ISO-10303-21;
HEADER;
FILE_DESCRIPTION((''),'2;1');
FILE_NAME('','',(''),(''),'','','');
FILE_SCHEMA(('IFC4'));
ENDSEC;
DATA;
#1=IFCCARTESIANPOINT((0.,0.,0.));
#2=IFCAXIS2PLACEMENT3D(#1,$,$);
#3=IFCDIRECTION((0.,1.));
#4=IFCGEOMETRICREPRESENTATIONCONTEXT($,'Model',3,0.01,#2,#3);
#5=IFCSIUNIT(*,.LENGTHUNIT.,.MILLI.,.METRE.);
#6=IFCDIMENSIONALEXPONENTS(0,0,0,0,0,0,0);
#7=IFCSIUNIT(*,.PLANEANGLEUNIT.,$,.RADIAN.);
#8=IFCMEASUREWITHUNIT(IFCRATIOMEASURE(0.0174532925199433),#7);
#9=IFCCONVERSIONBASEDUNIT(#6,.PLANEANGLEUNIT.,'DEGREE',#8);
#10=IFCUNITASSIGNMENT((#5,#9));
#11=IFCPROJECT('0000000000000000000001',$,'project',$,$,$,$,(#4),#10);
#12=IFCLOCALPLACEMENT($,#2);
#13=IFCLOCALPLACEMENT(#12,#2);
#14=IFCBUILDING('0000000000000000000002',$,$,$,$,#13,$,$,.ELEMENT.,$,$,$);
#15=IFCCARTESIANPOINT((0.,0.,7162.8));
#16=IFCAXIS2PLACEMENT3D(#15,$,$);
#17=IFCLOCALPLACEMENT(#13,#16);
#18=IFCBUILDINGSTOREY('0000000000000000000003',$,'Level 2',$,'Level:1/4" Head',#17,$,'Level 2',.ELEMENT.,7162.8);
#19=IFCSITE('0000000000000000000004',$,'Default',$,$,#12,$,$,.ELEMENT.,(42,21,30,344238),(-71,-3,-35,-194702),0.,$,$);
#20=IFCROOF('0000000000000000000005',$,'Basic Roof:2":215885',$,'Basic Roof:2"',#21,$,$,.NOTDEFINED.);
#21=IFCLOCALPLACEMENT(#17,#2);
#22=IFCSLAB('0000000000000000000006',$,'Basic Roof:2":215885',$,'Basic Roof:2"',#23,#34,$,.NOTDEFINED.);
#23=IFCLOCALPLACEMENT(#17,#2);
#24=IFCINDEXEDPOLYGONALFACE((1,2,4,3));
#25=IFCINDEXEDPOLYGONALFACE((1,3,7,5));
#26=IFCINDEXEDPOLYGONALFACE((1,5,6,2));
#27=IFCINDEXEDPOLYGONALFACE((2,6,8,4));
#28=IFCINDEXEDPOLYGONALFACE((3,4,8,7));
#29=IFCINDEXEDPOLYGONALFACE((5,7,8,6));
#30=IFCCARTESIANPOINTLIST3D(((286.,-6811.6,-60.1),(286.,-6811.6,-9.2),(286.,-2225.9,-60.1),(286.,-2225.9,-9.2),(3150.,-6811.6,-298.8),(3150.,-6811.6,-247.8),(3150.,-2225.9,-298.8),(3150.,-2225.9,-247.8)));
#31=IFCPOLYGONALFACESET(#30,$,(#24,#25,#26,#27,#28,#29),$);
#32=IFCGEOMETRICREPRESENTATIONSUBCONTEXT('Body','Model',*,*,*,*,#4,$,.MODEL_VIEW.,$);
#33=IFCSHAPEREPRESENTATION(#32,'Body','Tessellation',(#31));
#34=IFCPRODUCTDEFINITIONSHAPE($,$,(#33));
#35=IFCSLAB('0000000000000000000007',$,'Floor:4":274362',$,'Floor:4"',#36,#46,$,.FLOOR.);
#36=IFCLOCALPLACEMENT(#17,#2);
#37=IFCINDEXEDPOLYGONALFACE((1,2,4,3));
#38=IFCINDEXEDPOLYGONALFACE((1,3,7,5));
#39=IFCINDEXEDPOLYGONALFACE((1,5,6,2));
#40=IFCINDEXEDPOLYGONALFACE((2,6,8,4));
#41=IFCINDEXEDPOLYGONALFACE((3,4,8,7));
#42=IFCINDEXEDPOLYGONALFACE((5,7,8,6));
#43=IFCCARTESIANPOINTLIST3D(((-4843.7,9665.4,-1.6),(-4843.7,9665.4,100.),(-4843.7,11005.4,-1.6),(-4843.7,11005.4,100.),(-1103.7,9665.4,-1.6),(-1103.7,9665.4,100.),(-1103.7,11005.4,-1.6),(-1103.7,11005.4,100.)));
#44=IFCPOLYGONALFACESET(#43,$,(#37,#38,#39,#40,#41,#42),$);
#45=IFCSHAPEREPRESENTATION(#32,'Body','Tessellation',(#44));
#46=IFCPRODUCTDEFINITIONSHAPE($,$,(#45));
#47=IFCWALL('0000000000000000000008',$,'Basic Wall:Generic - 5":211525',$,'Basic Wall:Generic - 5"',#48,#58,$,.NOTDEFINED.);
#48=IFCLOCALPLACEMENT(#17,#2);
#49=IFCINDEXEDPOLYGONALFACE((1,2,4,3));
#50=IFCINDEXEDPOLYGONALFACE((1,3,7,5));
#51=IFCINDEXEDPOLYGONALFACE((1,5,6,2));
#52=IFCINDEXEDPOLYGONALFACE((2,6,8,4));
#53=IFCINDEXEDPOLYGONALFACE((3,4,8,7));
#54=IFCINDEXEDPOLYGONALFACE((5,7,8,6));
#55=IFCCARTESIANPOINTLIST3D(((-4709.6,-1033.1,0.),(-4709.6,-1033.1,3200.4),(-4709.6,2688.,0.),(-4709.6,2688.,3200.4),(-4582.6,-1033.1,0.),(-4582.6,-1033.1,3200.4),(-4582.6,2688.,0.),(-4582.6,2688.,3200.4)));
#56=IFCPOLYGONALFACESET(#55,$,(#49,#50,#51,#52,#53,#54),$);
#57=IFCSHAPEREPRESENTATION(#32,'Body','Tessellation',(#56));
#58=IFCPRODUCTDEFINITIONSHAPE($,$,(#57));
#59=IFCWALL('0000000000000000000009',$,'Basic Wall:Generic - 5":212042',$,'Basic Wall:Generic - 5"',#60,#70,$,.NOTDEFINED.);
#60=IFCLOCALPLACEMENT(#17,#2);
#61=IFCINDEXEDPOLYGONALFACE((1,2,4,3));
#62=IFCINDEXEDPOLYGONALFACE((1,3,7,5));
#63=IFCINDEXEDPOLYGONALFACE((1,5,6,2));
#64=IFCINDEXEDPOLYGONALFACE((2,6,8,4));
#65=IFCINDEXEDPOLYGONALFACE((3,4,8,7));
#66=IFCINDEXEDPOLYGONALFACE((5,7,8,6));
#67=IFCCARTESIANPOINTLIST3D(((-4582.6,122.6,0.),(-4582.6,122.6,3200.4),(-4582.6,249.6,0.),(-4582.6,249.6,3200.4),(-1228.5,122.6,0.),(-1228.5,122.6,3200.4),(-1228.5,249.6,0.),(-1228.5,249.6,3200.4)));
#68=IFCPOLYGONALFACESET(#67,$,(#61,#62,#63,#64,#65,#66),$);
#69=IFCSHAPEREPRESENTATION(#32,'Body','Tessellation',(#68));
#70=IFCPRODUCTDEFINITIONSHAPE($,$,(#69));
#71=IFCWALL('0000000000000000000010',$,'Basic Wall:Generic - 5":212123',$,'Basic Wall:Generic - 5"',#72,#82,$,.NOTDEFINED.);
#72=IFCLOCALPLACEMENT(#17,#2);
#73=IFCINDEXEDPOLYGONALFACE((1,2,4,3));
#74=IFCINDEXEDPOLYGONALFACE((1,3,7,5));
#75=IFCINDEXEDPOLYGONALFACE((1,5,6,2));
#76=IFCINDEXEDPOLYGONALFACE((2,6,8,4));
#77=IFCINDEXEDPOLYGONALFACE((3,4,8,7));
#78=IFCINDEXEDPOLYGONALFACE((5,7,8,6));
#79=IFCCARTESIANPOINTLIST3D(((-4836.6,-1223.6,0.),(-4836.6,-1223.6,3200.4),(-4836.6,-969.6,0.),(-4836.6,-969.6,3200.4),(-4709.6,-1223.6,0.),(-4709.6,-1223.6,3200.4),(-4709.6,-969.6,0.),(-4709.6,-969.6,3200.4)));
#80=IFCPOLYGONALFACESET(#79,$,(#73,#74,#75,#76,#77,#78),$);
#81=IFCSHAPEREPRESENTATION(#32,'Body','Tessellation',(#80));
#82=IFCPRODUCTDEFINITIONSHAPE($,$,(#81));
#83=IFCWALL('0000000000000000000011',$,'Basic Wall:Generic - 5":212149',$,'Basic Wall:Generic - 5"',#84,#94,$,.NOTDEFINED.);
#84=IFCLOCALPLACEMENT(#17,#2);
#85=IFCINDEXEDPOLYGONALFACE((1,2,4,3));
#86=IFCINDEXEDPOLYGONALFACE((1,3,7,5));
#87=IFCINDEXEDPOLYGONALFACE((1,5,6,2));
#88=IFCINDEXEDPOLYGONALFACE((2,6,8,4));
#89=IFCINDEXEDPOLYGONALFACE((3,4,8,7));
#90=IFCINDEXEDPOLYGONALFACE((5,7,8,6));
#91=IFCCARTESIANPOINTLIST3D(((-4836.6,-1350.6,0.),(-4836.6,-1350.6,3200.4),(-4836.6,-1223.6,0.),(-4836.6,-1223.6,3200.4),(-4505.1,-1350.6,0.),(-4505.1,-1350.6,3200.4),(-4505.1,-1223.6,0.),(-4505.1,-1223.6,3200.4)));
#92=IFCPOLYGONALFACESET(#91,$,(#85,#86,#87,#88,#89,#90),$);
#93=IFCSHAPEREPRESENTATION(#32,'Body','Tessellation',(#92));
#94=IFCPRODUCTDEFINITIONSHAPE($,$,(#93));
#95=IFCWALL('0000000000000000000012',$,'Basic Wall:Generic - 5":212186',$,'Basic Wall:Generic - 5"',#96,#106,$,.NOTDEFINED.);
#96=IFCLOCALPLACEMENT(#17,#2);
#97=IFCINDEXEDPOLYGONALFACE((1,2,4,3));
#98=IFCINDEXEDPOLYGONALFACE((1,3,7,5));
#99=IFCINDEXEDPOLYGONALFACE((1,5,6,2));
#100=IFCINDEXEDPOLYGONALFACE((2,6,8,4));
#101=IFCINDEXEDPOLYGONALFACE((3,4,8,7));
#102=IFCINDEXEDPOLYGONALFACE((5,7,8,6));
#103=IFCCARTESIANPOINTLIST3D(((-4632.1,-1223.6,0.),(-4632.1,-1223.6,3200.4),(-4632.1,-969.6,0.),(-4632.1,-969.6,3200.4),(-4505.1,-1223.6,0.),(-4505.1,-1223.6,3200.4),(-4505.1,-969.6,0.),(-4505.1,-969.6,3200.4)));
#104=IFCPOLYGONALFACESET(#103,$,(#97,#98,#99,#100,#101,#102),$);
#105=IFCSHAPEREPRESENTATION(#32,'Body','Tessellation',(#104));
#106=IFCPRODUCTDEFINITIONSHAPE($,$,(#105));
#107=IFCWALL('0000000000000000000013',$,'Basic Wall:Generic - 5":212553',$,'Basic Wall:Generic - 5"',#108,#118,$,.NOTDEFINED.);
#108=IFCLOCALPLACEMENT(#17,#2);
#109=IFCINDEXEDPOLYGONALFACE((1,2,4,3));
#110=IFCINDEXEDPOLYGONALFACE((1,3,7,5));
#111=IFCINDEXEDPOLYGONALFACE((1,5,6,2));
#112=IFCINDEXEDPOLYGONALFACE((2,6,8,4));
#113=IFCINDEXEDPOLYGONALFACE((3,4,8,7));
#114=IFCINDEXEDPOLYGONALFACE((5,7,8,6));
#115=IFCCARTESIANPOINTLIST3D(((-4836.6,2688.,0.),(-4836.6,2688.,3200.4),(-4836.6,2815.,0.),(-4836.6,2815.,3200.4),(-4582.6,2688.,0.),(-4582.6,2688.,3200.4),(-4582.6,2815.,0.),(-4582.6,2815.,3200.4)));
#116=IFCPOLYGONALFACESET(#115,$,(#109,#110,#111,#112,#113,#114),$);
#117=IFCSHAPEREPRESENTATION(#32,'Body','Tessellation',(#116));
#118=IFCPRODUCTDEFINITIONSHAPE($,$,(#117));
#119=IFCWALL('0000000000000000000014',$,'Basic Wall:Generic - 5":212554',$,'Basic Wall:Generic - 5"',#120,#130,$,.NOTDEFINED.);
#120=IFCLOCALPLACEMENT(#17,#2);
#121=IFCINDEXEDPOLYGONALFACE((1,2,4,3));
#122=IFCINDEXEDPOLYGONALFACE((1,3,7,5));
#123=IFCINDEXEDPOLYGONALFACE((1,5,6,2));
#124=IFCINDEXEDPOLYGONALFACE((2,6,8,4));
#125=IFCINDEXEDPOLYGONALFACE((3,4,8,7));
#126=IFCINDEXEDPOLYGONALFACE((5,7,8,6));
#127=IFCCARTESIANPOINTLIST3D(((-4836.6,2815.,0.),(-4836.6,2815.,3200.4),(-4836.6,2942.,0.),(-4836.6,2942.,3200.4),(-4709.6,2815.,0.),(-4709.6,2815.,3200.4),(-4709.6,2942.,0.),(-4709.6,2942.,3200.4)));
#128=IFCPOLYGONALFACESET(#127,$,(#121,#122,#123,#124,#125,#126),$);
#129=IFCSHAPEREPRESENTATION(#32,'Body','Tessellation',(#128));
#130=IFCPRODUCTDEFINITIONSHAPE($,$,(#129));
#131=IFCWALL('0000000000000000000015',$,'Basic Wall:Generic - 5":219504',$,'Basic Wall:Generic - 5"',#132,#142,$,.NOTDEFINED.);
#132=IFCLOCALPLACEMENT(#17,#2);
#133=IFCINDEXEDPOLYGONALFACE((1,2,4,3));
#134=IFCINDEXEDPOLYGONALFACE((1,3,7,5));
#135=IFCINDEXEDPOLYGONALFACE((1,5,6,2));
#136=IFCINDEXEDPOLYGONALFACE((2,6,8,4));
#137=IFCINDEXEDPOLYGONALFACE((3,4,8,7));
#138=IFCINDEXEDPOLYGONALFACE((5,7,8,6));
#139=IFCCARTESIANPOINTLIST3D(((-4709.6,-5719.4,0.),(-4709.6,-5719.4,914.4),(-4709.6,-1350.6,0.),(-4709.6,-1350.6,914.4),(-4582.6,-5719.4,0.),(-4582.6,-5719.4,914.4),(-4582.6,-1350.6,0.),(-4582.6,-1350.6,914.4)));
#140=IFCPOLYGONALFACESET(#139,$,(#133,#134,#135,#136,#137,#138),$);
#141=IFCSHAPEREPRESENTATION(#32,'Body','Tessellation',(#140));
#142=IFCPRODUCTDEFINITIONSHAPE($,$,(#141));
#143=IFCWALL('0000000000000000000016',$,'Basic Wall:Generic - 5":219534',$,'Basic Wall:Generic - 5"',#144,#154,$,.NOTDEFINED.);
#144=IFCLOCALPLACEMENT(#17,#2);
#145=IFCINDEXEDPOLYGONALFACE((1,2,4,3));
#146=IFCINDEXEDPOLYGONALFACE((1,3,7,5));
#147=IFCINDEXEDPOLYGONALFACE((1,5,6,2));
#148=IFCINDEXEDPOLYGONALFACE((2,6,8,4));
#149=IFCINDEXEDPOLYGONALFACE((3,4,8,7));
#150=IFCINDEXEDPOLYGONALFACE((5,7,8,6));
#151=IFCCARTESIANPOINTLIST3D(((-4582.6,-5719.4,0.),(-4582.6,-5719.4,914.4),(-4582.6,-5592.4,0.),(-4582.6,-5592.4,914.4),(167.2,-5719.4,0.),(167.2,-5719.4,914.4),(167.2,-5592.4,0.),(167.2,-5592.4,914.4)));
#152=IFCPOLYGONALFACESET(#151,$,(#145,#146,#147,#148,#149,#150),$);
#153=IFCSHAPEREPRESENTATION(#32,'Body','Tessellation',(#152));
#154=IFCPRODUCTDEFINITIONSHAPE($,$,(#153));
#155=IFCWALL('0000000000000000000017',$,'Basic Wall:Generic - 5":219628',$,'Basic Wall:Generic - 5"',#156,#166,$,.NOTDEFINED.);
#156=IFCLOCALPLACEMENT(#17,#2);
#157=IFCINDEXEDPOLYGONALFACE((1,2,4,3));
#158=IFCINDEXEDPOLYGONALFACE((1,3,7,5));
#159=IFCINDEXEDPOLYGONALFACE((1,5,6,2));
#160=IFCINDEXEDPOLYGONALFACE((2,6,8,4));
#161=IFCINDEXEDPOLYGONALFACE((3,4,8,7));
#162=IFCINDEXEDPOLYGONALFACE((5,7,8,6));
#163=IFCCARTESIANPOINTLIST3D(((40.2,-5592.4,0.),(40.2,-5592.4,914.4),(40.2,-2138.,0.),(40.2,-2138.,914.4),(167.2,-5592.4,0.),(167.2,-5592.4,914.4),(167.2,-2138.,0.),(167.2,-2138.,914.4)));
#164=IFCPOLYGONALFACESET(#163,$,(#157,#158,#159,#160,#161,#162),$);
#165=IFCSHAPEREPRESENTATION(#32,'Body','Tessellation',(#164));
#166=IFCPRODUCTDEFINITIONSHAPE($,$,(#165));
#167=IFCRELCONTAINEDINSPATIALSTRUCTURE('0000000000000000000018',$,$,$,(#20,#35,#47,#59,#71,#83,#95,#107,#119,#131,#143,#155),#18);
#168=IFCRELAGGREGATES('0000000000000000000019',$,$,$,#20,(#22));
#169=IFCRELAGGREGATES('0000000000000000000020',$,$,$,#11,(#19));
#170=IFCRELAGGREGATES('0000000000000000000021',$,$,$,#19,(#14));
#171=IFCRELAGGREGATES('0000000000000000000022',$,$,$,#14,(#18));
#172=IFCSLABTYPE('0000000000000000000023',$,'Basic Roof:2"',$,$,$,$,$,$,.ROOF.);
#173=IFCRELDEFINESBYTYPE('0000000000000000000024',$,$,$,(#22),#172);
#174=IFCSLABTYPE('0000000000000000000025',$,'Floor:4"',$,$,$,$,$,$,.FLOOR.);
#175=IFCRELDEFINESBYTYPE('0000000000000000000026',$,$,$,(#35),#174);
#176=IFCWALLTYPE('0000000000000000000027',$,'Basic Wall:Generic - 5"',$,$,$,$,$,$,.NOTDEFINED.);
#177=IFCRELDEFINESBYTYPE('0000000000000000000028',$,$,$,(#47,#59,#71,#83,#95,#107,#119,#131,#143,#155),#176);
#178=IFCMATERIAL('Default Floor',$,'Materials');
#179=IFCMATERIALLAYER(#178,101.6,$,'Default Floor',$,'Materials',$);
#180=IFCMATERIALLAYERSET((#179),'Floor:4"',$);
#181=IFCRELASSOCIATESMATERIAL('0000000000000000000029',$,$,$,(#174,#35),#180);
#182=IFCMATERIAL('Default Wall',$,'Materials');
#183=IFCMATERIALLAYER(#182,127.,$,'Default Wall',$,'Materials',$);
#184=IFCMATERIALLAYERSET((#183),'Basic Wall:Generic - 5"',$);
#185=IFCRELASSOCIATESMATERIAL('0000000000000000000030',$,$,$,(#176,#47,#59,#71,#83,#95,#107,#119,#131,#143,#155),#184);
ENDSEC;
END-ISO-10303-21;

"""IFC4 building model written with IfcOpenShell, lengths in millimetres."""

from ifc_helpers import new_model, entity, si_unit, converted_unit, direction, frame, origin, place, context, subcontext, project, spatial, indexed_curve, outline, extrude, material, layer, layer_set, type_object, element, aggregate, save


model = new_model("IFC4")

# Units and contexts
model_context = context("Model", 3, precision=0.01, world=origin(), true_north=direction((0.0, 1.0)))
body_context = subcontext(model_context, "Body", "Model", "MODEL_VIEW")
ifc_project = project(units=[si_unit("LENGTHUNIT", "METRE", prefix="MILLI"), converted_unit("PLANEANGLEUNIT", "DEGREE", entity("IfcRatioMeasure", 0.0174532925199433), si_unit("PLANEANGLEUNIT", "RADIAN"), dimensions=[0, 0, 0, 0, 0, 0, 0])], contexts=[model_context])

# Site, building, storey
site_placement = place(None, origin())
site = spatial("IfcSite", under=ifc_project, at=site_placement, Name="Default", CompositionType="ELEMENT", RefLatitude=(42, 21, 30, 344238), RefLongitude=(-71, -3, -35, -194702), RefElevation=0.0)
building_placement = place(site_placement, origin())
building = spatial("IfcBuilding", under=site, at=building_placement, CompositionType="ELEMENT")
storey_placement = place(building_placement, frame((0.0, 0.0, 7162.8)))
storey = spatial("IfcBuildingStorey", under=building, at=storey_placement, Name="Level 2", ObjectType="Level:1/4\" Head", LongName="Level 2", CompositionType="ELEMENT", Elevation=7162.8)

# Shared definitions
ifc_material_1 = material(Name="Default Floor", Category="Materials")
ifc_layer_1 = layer(ifc_material_1, 101.6, Name="Default Floor", Category="Materials")
ifc_layer_set_1 = layer_set([ifc_layer_1], Name="Floor:4\"")

# Roof, slab
roof_placement = place(storey_placement, frame((286.0, -6811.6, -298.8)))
roof = element("IfcRoof", 1, at=roof_placement, inside=storey, Name="Basic Roof:2\":215885", ObjectType="Basic Roof:2\"", PredefinedType="NOTDEFINED")
slab_type_1 = type_object("IfcSlabType", Name="Basic Roof:2\"", PredefinedType="ROOF")
slab_1_placement = place(roof_placement, origin())
slab_1 = element("IfcSlab", 2, at=slab_1_placement, type_object=slab_type_1, Name="Basic Roof:2\":215885", ObjectType="Basic Roof:2\"", PredefinedType="NOTDEFINED", context=body_context, shape_type="SweptSolid", body=[
    extrude(outline(indexed_curve([(-1437.0, 2292.9), (-1437.0, -2292.9), (1437.0, -2292.9), (1437.0, 2292.9), (-1437.0, 2292.9)], self_intersect=False)), frame((1432.0, 2292.9, 119.3), z_axis=(0.083045, 0.0, 0.996546), x_axis=(0.996546, 0.0, -0.083045)), (-0.083045, 0.0, 0.996546), 51.0),
])
aggregate(roof, [slab_1])

# Slab
slab_type_2 = type_object("IfcSlabType", Name="Floor:4\"", PredefinedType="FLOOR", material=ifc_layer_set_1)
slab_2_placement = place(storey_placement, origin())
element("IfcSlab", 3, at=slab_2_placement, inside=storey, type_object=slab_type_2, material=ifc_layer_set_1, Name="Floor:4\":274362", ObjectType="Floor:4\"", PredefinedType="FLOOR", context=body_context, shape_type="SweptSolid", body=[
    extrude(outline(indexed_curve([(-670.0, -1870.0), (670.0, -1870.0), (670.0, 1870.0), (-670.0, 1870.0), (-670.0, -1870.0)], self_intersect=False)), frame((-2973.7, 10335.4, 100.0), z_axis=(0.0, 0.0, -1.0), x_axis=(0.0, 1.0, 0.0)), (0.0, 0.0, 1.0), 101.6),
])

# Walls
ifc_material_2 = material(Name="Default Wall", Category="Materials")
ifc_layer_2 = layer(ifc_material_2, 127.0, Name="Default Wall", Category="Materials")
ifc_layer_set_2 = layer_set([ifc_layer_2], Name="Basic Wall:Generic - 5\"")
wall_type = type_object("IfcWallType", Name="Basic Wall:Generic - 5\"", PredefinedType="NOTDEFINED", material=ifc_layer_set_2)
wall_1_placement = place(storey_placement, frame((-4646.1, -1033.1, 0.0), z_axis=(0.0, 0.0, 1.0), x_axis=(0.0, 1.0, 0.0)))
element("IfcWall", 4, at=wall_1_placement, inside=storey, type_object=wall_type, material=ifc_layer_set_2, Name="Basic Wall:Generic - 5\":211525", ObjectType="Basic Wall:Generic - 5\"", PredefinedType="NOTDEFINED", context=body_context, shape_type="SweptSolid", body=[
    extrude(outline(indexed_curve([(3721.1, 63.5), (0.0, 63.5), (0.0, -63.5), (3721.1, -63.5), (3721.1, 63.5)], self_intersect=False)), origin(), (0.0, 0.0, 1.0), 3200.4),
])
wall_2_placement = place(storey_placement, frame((-1228.5, 186.1, 0.0), z_axis=(0.0, 0.0, 1.0), x_axis=(-1.0, 0.0, 0.0)))
element("IfcWall", 5, at=wall_2_placement, inside=storey, type_object=wall_type, material=ifc_layer_set_2, Name="Basic Wall:Generic - 5\":212042", ObjectType="Basic Wall:Generic - 5\"", PredefinedType="NOTDEFINED", context=body_context, shape_type="SweptSolid", body=[
    extrude(outline(indexed_curve([(3354.2, 63.5), (0.0, 63.5), (0.0, -63.5), (3354.2, -63.5), (3354.2, 63.5)], self_intersect=False)), origin(), (0.0, 0.0, 1.0), 3200.4),
])
wall_3_placement = place(storey_placement, frame((-4773.1, -969.6, 0.0), z_axis=(0.0, 0.0, 1.0), x_axis=(0.0, -1.0, 0.0)))
element("IfcWall", 6, at=wall_3_placement, inside=storey, type_object=wall_type, material=ifc_layer_set_2, Name="Basic Wall:Generic - 5\":212123", ObjectType="Basic Wall:Generic - 5\"", PredefinedType="NOTDEFINED", context=body_context, shape_type="SweptSolid", body=[
    extrude(outline(indexed_curve([(254.0, 63.5), (0.0, 63.5), (0.0, -63.5), (254.0, -63.5), (254.0, 63.5)], self_intersect=False)), origin(), (0.0, 0.0, 1.0), 3200.4),
])
wall_4_placement = place(storey_placement, frame((-4836.6, -1287.1, 0.0)))
element("IfcWall", 7, at=wall_4_placement, inside=storey, type_object=wall_type, material=ifc_layer_set_2, Name="Basic Wall:Generic - 5\":212149", ObjectType="Basic Wall:Generic - 5\"", PredefinedType="NOTDEFINED", context=body_context, shape_type="SweptSolid", body=[
    extrude(outline(indexed_curve([(331.6, 63.5), (0.0, 63.5), (0.0, -63.5), (331.6, -63.5), (331.6, 63.5)], self_intersect=False)), origin(), (0.0, 0.0, 1.0), 3200.4),
])
wall_5_placement = place(storey_placement, frame((-4568.6, -969.6, 0.0), z_axis=(0.0, 0.0, 1.0), x_axis=(0.0, -1.0, 0.0)))
element("IfcWall", 8, at=wall_5_placement, inside=storey, type_object=wall_type, material=ifc_layer_set_2, Name="Basic Wall:Generic - 5\":212186", ObjectType="Basic Wall:Generic - 5\"", PredefinedType="NOTDEFINED", context=body_context, shape_type="SweptSolid", body=[
    extrude(outline(indexed_curve([(254.0, 63.5), (0.0, 63.5), (0.0, -63.5), (254.0, -63.5), (254.0, 63.5)], self_intersect=False)), origin(), (0.0, 0.0, 1.0), 3200.4),
])
wall_6_placement = place(storey_placement, frame((-4582.6, 2751.5, 0.0), z_axis=(0.0, 0.0, 1.0), x_axis=(-1.0, 0.0, 0.0)))
element("IfcWall", 9, at=wall_6_placement, inside=storey, type_object=wall_type, material=ifc_layer_set_2, Name="Basic Wall:Generic - 5\":212553", ObjectType="Basic Wall:Generic - 5\"", PredefinedType="NOTDEFINED", context=body_context, shape_type="SweptSolid", body=[
    extrude(outline(indexed_curve([(254.0, 63.5), (0.0, 63.5), (0.0, -63.5), (254.0, -63.5), (254.0, 63.5)], self_intersect=False)), origin(), (0.0, 0.0, 1.0), 3200.4),
])
wall_7_placement = place(storey_placement, frame((-4773.1, 2815.0, 0.0), z_axis=(0.0, 0.0, 1.0), x_axis=(0.0, 1.0, 0.0)))
element("IfcWall", 10, at=wall_7_placement, inside=storey, type_object=wall_type, material=ifc_layer_set_2, Name="Basic Wall:Generic - 5\":212554", ObjectType="Basic Wall:Generic - 5\"", PredefinedType="NOTDEFINED", context=body_context, shape_type="SweptSolid", body=[
    extrude(outline(indexed_curve([(127.0, 63.5), (0.0, 63.5), (0.0, -63.5), (127.0, -63.5), (127.0, 63.5)], self_intersect=False)), origin(), (0.0, 0.0, 1.0), 3200.4),
])
wall_8_placement = place(storey_placement, frame((-4646.1, -1350.6, 0.0), z_axis=(0.0, 0.0, 1.0), x_axis=(0.0, -1.0, 0.0)))
element("IfcWall", 11, at=wall_8_placement, inside=storey, type_object=wall_type, material=ifc_layer_set_2, Name="Basic Wall:Generic - 5\":219504", ObjectType="Basic Wall:Generic - 5\"", PredefinedType="NOTDEFINED", context=body_context, shape_type="SweptSolid", body=[
    extrude(outline(indexed_curve([(4368.8, 63.5), (0.0, 63.5), (0.0, -63.5), (4368.8, -63.5), (4368.8, 63.5)], self_intersect=False)), origin(), (0.0, 0.0, 1.0), 914.4),
])
wall_9_placement = place(storey_placement, frame((-4582.6, -5655.9, 0.0)))
element("IfcWall", 12, at=wall_9_placement, inside=storey, type_object=wall_type, material=ifc_layer_set_2, Name="Basic Wall:Generic - 5\":219534", ObjectType="Basic Wall:Generic - 5\"", PredefinedType="NOTDEFINED", context=body_context, shape_type="SweptSolid", body=[
    extrude(outline(indexed_curve([(4749.8, 63.5), (0.0, 63.5), (0.0, -63.5), (4749.8, -63.5), (4749.8, 63.5)], self_intersect=False)), origin(), (0.0, 0.0, 1.0), 914.4),
])
wall_10_placement = place(storey_placement, frame((103.7, -5592.4, 0.0), z_axis=(0.0, 0.0, 1.0), x_axis=(0.0, 1.0, 0.0)))
element("IfcWall", 13, at=wall_10_placement, inside=storey, type_object=wall_type, material=ifc_layer_set_2, Name="Basic Wall:Generic - 5\":219628", ObjectType="Basic Wall:Generic - 5\"", PredefinedType="NOTDEFINED", context=body_context, shape_type="SweptSolid", body=[
    extrude(outline(indexed_curve([(3454.4, 63.5), (0.0, 63.5), (0.0, -63.5), (3454.4, -63.5), (3454.4, 63.5)], self_intersect=False)), origin(), (0.0, 0.0, 1.0), 914.4),
])

save(model, "model.ifc")
